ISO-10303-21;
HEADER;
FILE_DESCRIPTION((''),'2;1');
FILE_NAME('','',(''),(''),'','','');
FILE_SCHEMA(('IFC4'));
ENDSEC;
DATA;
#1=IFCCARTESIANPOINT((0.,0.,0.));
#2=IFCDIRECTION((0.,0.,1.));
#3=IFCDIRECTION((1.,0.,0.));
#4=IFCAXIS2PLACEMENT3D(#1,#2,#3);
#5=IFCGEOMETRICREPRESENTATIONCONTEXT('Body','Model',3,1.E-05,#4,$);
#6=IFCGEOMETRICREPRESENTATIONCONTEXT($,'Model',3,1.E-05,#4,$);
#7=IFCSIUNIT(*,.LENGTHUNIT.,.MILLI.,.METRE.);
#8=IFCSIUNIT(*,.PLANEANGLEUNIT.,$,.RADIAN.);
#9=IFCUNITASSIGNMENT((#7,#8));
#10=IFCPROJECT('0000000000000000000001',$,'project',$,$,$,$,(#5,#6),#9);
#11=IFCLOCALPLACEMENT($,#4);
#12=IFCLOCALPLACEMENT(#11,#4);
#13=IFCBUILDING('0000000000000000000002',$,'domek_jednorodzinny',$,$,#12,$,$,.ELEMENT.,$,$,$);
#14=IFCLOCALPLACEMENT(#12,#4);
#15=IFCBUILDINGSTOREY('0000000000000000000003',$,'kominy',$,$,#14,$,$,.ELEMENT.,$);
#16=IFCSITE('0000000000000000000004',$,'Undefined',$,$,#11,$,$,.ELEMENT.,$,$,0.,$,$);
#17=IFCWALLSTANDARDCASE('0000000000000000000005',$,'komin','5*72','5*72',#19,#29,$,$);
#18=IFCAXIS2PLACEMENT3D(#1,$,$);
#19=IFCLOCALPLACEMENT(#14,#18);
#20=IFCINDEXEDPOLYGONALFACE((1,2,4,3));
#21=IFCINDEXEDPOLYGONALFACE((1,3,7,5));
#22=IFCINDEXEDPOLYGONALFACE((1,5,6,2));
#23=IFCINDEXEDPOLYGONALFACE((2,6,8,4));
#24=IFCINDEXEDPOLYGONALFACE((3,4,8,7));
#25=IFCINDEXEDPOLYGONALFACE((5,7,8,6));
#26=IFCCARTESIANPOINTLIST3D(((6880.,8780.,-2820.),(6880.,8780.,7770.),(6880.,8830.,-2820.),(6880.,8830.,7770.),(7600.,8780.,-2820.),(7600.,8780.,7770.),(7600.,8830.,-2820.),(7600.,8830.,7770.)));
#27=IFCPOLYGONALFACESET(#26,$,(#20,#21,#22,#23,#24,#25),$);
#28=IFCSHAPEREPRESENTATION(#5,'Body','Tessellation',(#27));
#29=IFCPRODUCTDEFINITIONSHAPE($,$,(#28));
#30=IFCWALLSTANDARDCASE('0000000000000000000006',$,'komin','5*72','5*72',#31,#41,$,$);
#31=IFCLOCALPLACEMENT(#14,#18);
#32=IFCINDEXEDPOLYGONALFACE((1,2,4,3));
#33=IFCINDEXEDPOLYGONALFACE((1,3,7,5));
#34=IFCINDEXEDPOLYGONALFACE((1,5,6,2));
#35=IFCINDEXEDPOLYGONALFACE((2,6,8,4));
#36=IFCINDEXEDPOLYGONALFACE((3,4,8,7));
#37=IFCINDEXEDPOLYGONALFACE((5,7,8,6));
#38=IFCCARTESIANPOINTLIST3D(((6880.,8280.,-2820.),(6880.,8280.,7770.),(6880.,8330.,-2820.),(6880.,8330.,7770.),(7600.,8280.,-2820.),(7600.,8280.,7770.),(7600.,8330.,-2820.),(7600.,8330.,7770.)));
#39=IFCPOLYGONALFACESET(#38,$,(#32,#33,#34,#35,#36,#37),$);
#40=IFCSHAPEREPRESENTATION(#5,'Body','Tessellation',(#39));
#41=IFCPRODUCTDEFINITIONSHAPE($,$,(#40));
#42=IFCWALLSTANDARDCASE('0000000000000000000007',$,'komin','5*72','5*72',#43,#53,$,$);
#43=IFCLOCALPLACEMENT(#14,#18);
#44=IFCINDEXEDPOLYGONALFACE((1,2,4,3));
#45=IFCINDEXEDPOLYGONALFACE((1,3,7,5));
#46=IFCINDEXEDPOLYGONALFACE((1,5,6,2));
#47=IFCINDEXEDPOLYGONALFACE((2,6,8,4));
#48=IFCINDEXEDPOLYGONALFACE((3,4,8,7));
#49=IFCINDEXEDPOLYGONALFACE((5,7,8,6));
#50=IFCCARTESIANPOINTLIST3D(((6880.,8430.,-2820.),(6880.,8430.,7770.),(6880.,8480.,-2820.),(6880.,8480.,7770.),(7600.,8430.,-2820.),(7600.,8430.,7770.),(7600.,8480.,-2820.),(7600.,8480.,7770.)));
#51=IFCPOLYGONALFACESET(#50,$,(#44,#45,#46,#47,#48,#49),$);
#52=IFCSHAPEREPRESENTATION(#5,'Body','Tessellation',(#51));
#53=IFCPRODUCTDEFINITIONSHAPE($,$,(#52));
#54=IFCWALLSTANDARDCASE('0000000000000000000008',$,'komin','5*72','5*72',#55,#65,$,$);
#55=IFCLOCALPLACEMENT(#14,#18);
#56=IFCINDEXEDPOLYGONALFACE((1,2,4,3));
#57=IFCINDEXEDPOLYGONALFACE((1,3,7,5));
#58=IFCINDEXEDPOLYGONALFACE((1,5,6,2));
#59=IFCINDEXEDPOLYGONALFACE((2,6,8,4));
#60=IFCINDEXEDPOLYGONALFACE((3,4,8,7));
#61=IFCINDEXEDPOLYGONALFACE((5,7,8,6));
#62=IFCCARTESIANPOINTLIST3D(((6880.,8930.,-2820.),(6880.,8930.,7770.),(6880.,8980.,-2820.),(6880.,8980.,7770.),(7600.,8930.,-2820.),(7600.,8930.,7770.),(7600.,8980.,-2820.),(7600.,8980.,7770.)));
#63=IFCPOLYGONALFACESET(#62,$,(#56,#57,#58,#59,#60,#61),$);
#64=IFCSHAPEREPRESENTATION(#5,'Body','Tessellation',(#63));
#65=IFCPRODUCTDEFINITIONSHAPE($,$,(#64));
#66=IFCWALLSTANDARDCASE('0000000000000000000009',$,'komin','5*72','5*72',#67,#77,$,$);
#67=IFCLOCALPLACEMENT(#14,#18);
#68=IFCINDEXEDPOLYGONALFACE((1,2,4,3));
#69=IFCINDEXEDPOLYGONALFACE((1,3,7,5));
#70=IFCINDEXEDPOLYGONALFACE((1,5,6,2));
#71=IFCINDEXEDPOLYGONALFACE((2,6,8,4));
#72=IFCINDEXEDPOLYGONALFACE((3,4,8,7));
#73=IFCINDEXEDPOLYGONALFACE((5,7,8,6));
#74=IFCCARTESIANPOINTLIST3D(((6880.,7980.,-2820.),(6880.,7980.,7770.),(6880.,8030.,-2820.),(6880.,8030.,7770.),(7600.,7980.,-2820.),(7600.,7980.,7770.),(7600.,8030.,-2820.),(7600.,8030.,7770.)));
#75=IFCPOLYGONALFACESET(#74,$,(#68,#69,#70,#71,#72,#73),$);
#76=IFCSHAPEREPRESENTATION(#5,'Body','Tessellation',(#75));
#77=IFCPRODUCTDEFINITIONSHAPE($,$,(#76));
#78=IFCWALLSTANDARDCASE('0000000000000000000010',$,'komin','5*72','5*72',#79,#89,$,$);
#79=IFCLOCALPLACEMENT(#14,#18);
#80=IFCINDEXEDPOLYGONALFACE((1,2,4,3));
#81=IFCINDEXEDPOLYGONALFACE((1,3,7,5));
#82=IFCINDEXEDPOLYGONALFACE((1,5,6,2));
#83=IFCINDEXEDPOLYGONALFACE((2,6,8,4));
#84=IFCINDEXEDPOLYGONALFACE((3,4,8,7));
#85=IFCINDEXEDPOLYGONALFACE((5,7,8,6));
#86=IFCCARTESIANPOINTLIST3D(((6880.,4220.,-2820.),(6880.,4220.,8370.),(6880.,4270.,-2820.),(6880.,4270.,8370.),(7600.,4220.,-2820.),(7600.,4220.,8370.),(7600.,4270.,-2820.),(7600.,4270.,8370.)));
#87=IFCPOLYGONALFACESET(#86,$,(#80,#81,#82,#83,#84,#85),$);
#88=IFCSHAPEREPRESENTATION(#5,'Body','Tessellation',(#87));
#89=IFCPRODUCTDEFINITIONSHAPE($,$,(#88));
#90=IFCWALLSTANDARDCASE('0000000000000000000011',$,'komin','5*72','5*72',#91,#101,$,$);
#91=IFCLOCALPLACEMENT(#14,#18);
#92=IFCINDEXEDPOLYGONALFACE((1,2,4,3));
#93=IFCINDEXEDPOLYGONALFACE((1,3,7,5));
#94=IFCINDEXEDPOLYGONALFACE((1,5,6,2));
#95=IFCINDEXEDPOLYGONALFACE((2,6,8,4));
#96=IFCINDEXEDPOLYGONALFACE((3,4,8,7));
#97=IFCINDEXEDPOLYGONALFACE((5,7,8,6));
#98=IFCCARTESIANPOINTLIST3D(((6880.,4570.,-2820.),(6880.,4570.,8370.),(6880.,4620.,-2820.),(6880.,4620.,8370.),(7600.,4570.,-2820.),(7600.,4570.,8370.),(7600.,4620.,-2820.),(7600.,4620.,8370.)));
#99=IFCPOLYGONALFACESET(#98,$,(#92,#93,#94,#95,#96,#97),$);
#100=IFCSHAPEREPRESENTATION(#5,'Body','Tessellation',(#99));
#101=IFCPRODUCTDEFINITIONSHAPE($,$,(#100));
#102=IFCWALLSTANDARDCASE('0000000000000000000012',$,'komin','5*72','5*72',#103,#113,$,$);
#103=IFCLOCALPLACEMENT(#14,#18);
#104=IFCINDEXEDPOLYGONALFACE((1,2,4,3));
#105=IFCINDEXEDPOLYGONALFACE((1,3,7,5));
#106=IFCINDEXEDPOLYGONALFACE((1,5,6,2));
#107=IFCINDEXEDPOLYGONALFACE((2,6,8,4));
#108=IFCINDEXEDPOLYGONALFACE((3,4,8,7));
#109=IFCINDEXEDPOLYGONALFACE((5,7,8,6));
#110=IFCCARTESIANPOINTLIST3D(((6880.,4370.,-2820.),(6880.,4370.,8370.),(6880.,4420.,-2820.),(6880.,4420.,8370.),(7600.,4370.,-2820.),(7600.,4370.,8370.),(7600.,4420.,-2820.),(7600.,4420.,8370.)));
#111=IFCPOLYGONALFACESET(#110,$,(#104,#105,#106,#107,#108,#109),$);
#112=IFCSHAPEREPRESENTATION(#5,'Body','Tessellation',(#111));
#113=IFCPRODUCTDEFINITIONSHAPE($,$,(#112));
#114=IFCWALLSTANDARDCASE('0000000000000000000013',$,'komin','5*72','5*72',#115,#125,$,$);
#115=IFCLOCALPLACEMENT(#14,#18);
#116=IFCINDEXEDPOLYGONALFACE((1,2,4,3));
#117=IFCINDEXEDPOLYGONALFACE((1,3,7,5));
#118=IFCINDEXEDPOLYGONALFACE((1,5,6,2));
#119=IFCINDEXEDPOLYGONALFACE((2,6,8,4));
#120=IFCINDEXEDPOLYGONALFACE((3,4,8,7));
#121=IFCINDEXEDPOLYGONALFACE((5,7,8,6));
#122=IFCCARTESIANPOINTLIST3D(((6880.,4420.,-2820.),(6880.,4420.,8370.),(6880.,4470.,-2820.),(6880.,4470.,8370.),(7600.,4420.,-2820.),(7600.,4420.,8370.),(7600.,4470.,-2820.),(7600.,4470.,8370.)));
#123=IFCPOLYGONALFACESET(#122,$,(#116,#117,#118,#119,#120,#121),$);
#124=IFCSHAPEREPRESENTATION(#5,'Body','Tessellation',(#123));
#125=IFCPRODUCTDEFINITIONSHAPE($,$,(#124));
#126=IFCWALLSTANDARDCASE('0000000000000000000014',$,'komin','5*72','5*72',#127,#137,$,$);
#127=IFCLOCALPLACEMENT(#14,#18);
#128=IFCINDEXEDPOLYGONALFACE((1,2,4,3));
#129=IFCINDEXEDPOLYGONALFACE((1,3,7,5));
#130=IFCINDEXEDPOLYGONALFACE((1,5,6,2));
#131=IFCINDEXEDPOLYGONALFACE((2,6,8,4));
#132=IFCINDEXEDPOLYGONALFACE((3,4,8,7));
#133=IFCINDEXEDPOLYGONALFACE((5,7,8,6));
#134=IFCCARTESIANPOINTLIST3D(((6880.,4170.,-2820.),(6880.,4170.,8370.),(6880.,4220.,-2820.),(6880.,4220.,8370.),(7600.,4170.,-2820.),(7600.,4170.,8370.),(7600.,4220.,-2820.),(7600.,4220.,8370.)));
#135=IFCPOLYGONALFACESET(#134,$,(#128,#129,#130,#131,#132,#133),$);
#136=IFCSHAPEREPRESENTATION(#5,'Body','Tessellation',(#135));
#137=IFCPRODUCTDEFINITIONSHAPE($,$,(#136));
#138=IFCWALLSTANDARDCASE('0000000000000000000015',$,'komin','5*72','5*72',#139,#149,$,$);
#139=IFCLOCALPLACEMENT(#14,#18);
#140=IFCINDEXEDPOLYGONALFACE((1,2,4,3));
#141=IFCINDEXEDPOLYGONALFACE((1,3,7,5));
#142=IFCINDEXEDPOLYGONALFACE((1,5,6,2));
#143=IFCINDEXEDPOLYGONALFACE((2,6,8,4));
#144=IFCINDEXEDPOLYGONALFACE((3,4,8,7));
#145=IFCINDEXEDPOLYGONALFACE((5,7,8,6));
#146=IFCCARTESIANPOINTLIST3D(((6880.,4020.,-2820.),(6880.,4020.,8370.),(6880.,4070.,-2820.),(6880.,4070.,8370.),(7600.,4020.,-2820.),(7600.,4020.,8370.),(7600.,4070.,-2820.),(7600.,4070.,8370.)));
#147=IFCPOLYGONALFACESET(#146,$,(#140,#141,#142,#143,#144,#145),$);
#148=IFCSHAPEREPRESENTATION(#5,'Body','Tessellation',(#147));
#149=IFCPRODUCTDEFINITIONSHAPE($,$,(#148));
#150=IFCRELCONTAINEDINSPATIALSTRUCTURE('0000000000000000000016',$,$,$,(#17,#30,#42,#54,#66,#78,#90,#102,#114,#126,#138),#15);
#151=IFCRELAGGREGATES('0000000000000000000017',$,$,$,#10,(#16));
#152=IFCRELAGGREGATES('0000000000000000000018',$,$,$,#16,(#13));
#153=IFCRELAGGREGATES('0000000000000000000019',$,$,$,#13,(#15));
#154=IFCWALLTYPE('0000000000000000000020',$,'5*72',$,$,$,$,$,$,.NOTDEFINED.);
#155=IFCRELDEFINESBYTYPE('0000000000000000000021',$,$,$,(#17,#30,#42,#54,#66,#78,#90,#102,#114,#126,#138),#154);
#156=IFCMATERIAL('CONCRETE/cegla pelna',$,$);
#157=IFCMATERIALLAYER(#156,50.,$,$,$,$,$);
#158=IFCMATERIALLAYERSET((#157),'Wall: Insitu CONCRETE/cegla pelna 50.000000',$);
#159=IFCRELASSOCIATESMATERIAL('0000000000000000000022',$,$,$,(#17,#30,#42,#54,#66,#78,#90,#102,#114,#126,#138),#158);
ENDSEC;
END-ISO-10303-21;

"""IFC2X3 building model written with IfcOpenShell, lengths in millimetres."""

from ifc_helpers import new_model, si_unit, frame, frame_2d, origin_with_axes, place, context, project, spatial, rectangle, extrude, material, layer, layer_set, layer_usage, type_object, element, save


model = new_model("IFC2X3")

# Units and contexts
model_context_1 = context("Model", 3, precision=1e-05, world=origin_with_axes(), identifier="Body")
model_context_2 = context("Model", 3, precision=1e-05, world=origin_with_axes())
ifc_project = project(units=[si_unit("LENGTHUNIT", "METRE", prefix="MILLI"), si_unit("PLANEANGLEUNIT", "RADIAN")], contexts=[model_context_1, model_context_2])

# Site, building, storey
site_placement = place(None, origin_with_axes())
site = spatial("IfcSite", under=ifc_project, at=site_placement, Name="Undefined", CompositionType="ELEMENT", RefElevation=0.0)
building_placement = place(site_placement, origin_with_axes())
building = spatial("IfcBuilding", under=site, at=building_placement, Name="domek_jednorodzinny", CompositionType="ELEMENT")
storey_placement = place(building_placement, origin_with_axes())
storey = spatial("IfcBuildingStorey", under=building, at=storey_placement, Name="kominy", CompositionType="ELEMENT")

# Walls
ifc_material = material(Name="CONCRETE/cegla pelna")
ifc_layer = layer(ifc_material, 50.0)
ifc_layer_set = layer_set([ifc_layer], Name="Wall: Insitu CONCRETE/cegla pelna 50.000000")
ifc_layer_usage_1 = layer_usage(ifc_layer_set, "AXIS2", "POSITIVE", -25.0)
wall_type_1 = type_object("IfcWallType", Name="5*72", PredefinedType="NOTDEFINED")
wall_1_placement = place(storey_placement, frame((6880.0, 8805.0, -2820.0), z_axis=(0.0, 0.0, 1.0), x_axis=(1.0, 0.0, 0.0)))
element("IfcWallStandardCase", 1, at=wall_1_placement, inside=storey, type_object=wall_type_1, material=ifc_layer_usage_1, Name="komin", Description="5*72", ObjectType="5*72", context=model_context_1, shape_type="SweptSolid", body=[
    extrude(rectangle(XDim=720.0, YDim=50.0, at=frame_2d((0.0, 360.0), x_axis=(0.0, -1.0))), frame((0.0, 0.0, 0.0), z_axis=(0.0, 0.0, 1.0), x_axis=(0.0, -1.0, 0.0)), (0.0, 0.0, 1.0), 10590.0),
])
ifc_layer_usage_2 = layer_usage(ifc_layer_set, "AXIS2", "POSITIVE", -25.0)
wall_2_placement = place(storey_placement, frame((6880.0, 8305.0, -2820.0), z_axis=(0.0, 0.0, 1.0), x_axis=(1.0, 0.0, 0.0)))
element("IfcWallStandardCase", 2, at=wall_2_placement, inside=storey, type_object=wall_type_1, material=ifc_layer_usage_2, Name="komin", Description="5*72", ObjectType="5*72", context=model_context_1, shape_type="SweptSolid", body=[
    extrude(rectangle(XDim=720.0, YDim=50.0, at=frame_2d((0.0, 360.0), x_axis=(0.0, -1.0))), frame((0.0, 0.0, 0.0), z_axis=(0.0, 0.0, 1.0), x_axis=(0.0, -1.0, 0.0)), (0.0, 0.0, 1.0), 10590.0),
])
ifc_layer_usage_3 = layer_usage(ifc_layer_set, "AXIS2", "POSITIVE", -25.0)
wall_3_placement = place(storey_placement, frame((6880.0, 8455.0, -2820.0), z_axis=(0.0, 0.0, 1.0), x_axis=(1.0, 0.0, 0.0)))
element("IfcWallStandardCase", 3, at=wall_3_placement, inside=storey, type_object=wall_type_1, material=ifc_layer_usage_3, Name="komin", Description="5*72", ObjectType="5*72", context=model_context_1, shape_type="SweptSolid", body=[
    extrude(rectangle(XDim=720.0, YDim=50.0, at=frame_2d((0.0, 360.0), x_axis=(0.0, -1.0))), frame((0.0, 0.0, 0.0), z_axis=(0.0, 0.0, 1.0), x_axis=(0.0, -1.0, 0.0)), (0.0, 0.0, 1.0), 10590.0),
])
ifc_layer_usage_4 = layer_usage(ifc_layer_set, "AXIS2", "POSITIVE", -25.0)
wall_4_placement = place(storey_placement, frame((6880.0, 8955.0, -2820.0), z_axis=(0.0, 0.0, 1.0), x_axis=(1.0, 0.0, 0.0)))
element("IfcWallStandardCase", 4, at=wall_4_placement, inside=storey, type_object=wall_type_1, material=ifc_layer_usage_4, Name="komin", Description="5*72", ObjectType="5*72", context=model_context_1, shape_type="SweptSolid", body=[
    extrude(rectangle(XDim=720.0, YDim=50.0, at=frame_2d((0.0, 360.0), x_axis=(0.0, -1.0))), frame((0.0, 0.0, 0.0), z_axis=(0.0, 0.0, 1.0), x_axis=(0.0, -1.0, 0.0)), (0.0, 0.0, 1.0), 10590.0),
])
ifc_layer_usage_5 = layer_usage(ifc_layer_set, "AXIS2", "POSITIVE", -25.0)
wall_5_placement = place(storey_placement, frame((6880.0, 8005.0, -2820.0), z_axis=(0.0, 0.0, 1.0), x_axis=(1.0, 0.0, 0.0)))
element("IfcWallStandardCase", 5, at=wall_5_placement, inside=storey, type_object=wall_type_1, material=ifc_layer_usage_5, Name="komin", Description="5*72", ObjectType="5*72", context=model_context_1, shape_type="SweptSolid", body=[
    extrude(rectangle(XDim=720.0, YDim=50.0, at=frame_2d((0.0, 360.0), x_axis=(0.0, -1.0))), frame((0.0, 0.0, 0.0), z_axis=(0.0, 0.0, 1.0), x_axis=(0.0, -1.0, 0.0)), (0.0, 0.0, 1.0), 10590.0),
])
ifc_layer_usage_6 = layer_usage(ifc_layer_set, "AXIS2", "POSITIVE", -25.0)
wall_6_placement = place(storey_placement, frame((6880.0, 4245.0, -2820.0), z_axis=(0.0, 0.0, 1.0), x_axis=(1.0, 0.0, 0.0)))
element("IfcWallStandardCase", 6, at=wall_6_placement, inside=storey, type_object=wall_type_1, material=ifc_layer_usage_6, Name="komin", Description="5*72", ObjectType="5*72", context=model_context_1, shape_type="SweptSolid", body=[
    extrude(rectangle(XDim=720.0, YDim=50.0, at=frame_2d((0.0, 360.0), x_axis=(0.0, -1.0))), frame((0.0, 0.0, 0.0), z_axis=(0.0, 0.0, 1.0), x_axis=(0.0, -1.0, 0.0)), (0.0, 0.0, 1.0), 11190.0),
])
ifc_layer_usage_7 = layer_usage(ifc_layer_set, "AXIS2", "POSITIVE", -25.0)
wall_7_placement = place(storey_placement, frame((6880.0, 4595.0, -2820.0), z_axis=(0.0, 0.0, 1.0), x_axis=(1.0, 0.0, 0.0)))
element("IfcWallStandardCase", 7, at=wall_7_placement, inside=storey, type_object=wall_type_1, material=ifc_layer_usage_7, Name="komin", Description="5*72", ObjectType="5*72", context=model_context_1, shape_type="SweptSolid", body=[
    extrude(rectangle(XDim=720.0, YDim=50.0, at=frame_2d((0.0, 360.0), x_axis=(0.0, -1.0))), frame((0.0, 0.0, 0.0), z_axis=(0.0, 0.0, 1.0), x_axis=(0.0, -1.0, 0.0)), (0.0, 0.0, 1.0), 11190.0),
])
ifc_layer_usage_8 = layer_usage(ifc_layer_set, "AXIS2", "POSITIVE", -25.0)
wall_8_placement = place(storey_placement, frame((6880.0, 4395.0, -2820.0), z_axis=(0.0, 0.0, 1.0), x_axis=(1.0, 0.0, 0.0)))
element("IfcWallStandardCase", 8, at=wall_8_placement, inside=storey, type_object=wall_type_1, material=ifc_layer_usage_8, Name="komin", Description="5*72", ObjectType="5*72", context=model_context_1, shape_type="SweptSolid", body=[
    extrude(rectangle(XDim=720.0, YDim=50.0, at=frame_2d((0.0, 360.0), x_axis=(0.0, -1.0))), frame((0.0, 0.0, 0.0), z_axis=(0.0, 0.0, 1.0), x_axis=(0.0, -1.0, 0.0)), (0.0, 0.0, 1.0), 11190.0),
])
ifc_layer_usage_9 = layer_usage(ifc_layer_set, "AXIS2", "POSITIVE", -25.0)
wall_9_placement = place(storey_placement, frame((6880.0, 4445.0, -2820.0), z_axis=(0.0, 0.0, 1.0), x_axis=(1.0, 0.0, 0.0)))
element("IfcWallStandardCase", 9, at=wall_9_placement, inside=storey, type_object=wall_type_1, material=ifc_layer_usage_9, Name="komin", Description="5*72", ObjectType="5*72", context=model_context_1, shape_type="SweptSolid", body=[
    extrude(rectangle(XDim=720.0, YDim=50.0, at=frame_2d((0.0, 360.0), x_axis=(0.0, -1.0))), frame((0.0, 0.0, 0.0), z_axis=(0.0, 0.0, 1.0), x_axis=(0.0, -1.0, 0.0)), (0.0, 0.0, 1.0), 11190.0),
])
ifc_layer_usage_10 = layer_usage(ifc_layer_set, "AXIS2", "POSITIVE", -25.0)
wall_10_placement = place(storey_placement, frame((6880.0, 4195.0, -2820.0), z_axis=(0.0, 0.0, 1.0), x_axis=(1.0, 0.0, 0.0)))
element("IfcWallStandardCase", 10, at=wall_10_placement, inside=storey, type_object=wall_type_1, material=ifc_layer_usage_10, Name="komin", Description="5*72", ObjectType="5*72", context=model_context_1, shape_type="SweptSolid", body=[
    extrude(rectangle(XDim=720.0, YDim=50.0, at=frame_2d((0.0, 360.0), x_axis=(0.0, -1.0))), frame((0.0, 0.0, 0.0), z_axis=(0.0, 0.0, 1.0), x_axis=(0.0, -1.0, 0.0)), (0.0, 0.0, 1.0), 11190.0),
])
ifc_layer_usage_11 = layer_usage(ifc_layer_set, "AXIS2", "POSITIVE", -25.0)
wall_11_placement = place(storey_placement, frame((6880.0, 4045.0, -2820.0), z_axis=(0.0, 0.0, 1.0), x_axis=(1.0, 0.0, 0.0)))
element("IfcWallStandardCase", 11, at=wall_11_placement, inside=storey, type_object=wall_type_1, material=ifc_layer_usage_11, Name="komin", Description="5*72", ObjectType="5*72", context=model_context_1, shape_type="SweptSolid", body=[
    extrude(rectangle(XDim=720.0, YDim=50.0, at=frame_2d((0.0, 360.0), x_axis=(0.0, -1.0))), frame((0.0, 0.0, 0.0), z_axis=(0.0, 0.0, 1.0), x_axis=(0.0, -1.0, 0.0)), (0.0, 0.0, 1.0), 11190.0),
])

save(model, "model.ifc")
